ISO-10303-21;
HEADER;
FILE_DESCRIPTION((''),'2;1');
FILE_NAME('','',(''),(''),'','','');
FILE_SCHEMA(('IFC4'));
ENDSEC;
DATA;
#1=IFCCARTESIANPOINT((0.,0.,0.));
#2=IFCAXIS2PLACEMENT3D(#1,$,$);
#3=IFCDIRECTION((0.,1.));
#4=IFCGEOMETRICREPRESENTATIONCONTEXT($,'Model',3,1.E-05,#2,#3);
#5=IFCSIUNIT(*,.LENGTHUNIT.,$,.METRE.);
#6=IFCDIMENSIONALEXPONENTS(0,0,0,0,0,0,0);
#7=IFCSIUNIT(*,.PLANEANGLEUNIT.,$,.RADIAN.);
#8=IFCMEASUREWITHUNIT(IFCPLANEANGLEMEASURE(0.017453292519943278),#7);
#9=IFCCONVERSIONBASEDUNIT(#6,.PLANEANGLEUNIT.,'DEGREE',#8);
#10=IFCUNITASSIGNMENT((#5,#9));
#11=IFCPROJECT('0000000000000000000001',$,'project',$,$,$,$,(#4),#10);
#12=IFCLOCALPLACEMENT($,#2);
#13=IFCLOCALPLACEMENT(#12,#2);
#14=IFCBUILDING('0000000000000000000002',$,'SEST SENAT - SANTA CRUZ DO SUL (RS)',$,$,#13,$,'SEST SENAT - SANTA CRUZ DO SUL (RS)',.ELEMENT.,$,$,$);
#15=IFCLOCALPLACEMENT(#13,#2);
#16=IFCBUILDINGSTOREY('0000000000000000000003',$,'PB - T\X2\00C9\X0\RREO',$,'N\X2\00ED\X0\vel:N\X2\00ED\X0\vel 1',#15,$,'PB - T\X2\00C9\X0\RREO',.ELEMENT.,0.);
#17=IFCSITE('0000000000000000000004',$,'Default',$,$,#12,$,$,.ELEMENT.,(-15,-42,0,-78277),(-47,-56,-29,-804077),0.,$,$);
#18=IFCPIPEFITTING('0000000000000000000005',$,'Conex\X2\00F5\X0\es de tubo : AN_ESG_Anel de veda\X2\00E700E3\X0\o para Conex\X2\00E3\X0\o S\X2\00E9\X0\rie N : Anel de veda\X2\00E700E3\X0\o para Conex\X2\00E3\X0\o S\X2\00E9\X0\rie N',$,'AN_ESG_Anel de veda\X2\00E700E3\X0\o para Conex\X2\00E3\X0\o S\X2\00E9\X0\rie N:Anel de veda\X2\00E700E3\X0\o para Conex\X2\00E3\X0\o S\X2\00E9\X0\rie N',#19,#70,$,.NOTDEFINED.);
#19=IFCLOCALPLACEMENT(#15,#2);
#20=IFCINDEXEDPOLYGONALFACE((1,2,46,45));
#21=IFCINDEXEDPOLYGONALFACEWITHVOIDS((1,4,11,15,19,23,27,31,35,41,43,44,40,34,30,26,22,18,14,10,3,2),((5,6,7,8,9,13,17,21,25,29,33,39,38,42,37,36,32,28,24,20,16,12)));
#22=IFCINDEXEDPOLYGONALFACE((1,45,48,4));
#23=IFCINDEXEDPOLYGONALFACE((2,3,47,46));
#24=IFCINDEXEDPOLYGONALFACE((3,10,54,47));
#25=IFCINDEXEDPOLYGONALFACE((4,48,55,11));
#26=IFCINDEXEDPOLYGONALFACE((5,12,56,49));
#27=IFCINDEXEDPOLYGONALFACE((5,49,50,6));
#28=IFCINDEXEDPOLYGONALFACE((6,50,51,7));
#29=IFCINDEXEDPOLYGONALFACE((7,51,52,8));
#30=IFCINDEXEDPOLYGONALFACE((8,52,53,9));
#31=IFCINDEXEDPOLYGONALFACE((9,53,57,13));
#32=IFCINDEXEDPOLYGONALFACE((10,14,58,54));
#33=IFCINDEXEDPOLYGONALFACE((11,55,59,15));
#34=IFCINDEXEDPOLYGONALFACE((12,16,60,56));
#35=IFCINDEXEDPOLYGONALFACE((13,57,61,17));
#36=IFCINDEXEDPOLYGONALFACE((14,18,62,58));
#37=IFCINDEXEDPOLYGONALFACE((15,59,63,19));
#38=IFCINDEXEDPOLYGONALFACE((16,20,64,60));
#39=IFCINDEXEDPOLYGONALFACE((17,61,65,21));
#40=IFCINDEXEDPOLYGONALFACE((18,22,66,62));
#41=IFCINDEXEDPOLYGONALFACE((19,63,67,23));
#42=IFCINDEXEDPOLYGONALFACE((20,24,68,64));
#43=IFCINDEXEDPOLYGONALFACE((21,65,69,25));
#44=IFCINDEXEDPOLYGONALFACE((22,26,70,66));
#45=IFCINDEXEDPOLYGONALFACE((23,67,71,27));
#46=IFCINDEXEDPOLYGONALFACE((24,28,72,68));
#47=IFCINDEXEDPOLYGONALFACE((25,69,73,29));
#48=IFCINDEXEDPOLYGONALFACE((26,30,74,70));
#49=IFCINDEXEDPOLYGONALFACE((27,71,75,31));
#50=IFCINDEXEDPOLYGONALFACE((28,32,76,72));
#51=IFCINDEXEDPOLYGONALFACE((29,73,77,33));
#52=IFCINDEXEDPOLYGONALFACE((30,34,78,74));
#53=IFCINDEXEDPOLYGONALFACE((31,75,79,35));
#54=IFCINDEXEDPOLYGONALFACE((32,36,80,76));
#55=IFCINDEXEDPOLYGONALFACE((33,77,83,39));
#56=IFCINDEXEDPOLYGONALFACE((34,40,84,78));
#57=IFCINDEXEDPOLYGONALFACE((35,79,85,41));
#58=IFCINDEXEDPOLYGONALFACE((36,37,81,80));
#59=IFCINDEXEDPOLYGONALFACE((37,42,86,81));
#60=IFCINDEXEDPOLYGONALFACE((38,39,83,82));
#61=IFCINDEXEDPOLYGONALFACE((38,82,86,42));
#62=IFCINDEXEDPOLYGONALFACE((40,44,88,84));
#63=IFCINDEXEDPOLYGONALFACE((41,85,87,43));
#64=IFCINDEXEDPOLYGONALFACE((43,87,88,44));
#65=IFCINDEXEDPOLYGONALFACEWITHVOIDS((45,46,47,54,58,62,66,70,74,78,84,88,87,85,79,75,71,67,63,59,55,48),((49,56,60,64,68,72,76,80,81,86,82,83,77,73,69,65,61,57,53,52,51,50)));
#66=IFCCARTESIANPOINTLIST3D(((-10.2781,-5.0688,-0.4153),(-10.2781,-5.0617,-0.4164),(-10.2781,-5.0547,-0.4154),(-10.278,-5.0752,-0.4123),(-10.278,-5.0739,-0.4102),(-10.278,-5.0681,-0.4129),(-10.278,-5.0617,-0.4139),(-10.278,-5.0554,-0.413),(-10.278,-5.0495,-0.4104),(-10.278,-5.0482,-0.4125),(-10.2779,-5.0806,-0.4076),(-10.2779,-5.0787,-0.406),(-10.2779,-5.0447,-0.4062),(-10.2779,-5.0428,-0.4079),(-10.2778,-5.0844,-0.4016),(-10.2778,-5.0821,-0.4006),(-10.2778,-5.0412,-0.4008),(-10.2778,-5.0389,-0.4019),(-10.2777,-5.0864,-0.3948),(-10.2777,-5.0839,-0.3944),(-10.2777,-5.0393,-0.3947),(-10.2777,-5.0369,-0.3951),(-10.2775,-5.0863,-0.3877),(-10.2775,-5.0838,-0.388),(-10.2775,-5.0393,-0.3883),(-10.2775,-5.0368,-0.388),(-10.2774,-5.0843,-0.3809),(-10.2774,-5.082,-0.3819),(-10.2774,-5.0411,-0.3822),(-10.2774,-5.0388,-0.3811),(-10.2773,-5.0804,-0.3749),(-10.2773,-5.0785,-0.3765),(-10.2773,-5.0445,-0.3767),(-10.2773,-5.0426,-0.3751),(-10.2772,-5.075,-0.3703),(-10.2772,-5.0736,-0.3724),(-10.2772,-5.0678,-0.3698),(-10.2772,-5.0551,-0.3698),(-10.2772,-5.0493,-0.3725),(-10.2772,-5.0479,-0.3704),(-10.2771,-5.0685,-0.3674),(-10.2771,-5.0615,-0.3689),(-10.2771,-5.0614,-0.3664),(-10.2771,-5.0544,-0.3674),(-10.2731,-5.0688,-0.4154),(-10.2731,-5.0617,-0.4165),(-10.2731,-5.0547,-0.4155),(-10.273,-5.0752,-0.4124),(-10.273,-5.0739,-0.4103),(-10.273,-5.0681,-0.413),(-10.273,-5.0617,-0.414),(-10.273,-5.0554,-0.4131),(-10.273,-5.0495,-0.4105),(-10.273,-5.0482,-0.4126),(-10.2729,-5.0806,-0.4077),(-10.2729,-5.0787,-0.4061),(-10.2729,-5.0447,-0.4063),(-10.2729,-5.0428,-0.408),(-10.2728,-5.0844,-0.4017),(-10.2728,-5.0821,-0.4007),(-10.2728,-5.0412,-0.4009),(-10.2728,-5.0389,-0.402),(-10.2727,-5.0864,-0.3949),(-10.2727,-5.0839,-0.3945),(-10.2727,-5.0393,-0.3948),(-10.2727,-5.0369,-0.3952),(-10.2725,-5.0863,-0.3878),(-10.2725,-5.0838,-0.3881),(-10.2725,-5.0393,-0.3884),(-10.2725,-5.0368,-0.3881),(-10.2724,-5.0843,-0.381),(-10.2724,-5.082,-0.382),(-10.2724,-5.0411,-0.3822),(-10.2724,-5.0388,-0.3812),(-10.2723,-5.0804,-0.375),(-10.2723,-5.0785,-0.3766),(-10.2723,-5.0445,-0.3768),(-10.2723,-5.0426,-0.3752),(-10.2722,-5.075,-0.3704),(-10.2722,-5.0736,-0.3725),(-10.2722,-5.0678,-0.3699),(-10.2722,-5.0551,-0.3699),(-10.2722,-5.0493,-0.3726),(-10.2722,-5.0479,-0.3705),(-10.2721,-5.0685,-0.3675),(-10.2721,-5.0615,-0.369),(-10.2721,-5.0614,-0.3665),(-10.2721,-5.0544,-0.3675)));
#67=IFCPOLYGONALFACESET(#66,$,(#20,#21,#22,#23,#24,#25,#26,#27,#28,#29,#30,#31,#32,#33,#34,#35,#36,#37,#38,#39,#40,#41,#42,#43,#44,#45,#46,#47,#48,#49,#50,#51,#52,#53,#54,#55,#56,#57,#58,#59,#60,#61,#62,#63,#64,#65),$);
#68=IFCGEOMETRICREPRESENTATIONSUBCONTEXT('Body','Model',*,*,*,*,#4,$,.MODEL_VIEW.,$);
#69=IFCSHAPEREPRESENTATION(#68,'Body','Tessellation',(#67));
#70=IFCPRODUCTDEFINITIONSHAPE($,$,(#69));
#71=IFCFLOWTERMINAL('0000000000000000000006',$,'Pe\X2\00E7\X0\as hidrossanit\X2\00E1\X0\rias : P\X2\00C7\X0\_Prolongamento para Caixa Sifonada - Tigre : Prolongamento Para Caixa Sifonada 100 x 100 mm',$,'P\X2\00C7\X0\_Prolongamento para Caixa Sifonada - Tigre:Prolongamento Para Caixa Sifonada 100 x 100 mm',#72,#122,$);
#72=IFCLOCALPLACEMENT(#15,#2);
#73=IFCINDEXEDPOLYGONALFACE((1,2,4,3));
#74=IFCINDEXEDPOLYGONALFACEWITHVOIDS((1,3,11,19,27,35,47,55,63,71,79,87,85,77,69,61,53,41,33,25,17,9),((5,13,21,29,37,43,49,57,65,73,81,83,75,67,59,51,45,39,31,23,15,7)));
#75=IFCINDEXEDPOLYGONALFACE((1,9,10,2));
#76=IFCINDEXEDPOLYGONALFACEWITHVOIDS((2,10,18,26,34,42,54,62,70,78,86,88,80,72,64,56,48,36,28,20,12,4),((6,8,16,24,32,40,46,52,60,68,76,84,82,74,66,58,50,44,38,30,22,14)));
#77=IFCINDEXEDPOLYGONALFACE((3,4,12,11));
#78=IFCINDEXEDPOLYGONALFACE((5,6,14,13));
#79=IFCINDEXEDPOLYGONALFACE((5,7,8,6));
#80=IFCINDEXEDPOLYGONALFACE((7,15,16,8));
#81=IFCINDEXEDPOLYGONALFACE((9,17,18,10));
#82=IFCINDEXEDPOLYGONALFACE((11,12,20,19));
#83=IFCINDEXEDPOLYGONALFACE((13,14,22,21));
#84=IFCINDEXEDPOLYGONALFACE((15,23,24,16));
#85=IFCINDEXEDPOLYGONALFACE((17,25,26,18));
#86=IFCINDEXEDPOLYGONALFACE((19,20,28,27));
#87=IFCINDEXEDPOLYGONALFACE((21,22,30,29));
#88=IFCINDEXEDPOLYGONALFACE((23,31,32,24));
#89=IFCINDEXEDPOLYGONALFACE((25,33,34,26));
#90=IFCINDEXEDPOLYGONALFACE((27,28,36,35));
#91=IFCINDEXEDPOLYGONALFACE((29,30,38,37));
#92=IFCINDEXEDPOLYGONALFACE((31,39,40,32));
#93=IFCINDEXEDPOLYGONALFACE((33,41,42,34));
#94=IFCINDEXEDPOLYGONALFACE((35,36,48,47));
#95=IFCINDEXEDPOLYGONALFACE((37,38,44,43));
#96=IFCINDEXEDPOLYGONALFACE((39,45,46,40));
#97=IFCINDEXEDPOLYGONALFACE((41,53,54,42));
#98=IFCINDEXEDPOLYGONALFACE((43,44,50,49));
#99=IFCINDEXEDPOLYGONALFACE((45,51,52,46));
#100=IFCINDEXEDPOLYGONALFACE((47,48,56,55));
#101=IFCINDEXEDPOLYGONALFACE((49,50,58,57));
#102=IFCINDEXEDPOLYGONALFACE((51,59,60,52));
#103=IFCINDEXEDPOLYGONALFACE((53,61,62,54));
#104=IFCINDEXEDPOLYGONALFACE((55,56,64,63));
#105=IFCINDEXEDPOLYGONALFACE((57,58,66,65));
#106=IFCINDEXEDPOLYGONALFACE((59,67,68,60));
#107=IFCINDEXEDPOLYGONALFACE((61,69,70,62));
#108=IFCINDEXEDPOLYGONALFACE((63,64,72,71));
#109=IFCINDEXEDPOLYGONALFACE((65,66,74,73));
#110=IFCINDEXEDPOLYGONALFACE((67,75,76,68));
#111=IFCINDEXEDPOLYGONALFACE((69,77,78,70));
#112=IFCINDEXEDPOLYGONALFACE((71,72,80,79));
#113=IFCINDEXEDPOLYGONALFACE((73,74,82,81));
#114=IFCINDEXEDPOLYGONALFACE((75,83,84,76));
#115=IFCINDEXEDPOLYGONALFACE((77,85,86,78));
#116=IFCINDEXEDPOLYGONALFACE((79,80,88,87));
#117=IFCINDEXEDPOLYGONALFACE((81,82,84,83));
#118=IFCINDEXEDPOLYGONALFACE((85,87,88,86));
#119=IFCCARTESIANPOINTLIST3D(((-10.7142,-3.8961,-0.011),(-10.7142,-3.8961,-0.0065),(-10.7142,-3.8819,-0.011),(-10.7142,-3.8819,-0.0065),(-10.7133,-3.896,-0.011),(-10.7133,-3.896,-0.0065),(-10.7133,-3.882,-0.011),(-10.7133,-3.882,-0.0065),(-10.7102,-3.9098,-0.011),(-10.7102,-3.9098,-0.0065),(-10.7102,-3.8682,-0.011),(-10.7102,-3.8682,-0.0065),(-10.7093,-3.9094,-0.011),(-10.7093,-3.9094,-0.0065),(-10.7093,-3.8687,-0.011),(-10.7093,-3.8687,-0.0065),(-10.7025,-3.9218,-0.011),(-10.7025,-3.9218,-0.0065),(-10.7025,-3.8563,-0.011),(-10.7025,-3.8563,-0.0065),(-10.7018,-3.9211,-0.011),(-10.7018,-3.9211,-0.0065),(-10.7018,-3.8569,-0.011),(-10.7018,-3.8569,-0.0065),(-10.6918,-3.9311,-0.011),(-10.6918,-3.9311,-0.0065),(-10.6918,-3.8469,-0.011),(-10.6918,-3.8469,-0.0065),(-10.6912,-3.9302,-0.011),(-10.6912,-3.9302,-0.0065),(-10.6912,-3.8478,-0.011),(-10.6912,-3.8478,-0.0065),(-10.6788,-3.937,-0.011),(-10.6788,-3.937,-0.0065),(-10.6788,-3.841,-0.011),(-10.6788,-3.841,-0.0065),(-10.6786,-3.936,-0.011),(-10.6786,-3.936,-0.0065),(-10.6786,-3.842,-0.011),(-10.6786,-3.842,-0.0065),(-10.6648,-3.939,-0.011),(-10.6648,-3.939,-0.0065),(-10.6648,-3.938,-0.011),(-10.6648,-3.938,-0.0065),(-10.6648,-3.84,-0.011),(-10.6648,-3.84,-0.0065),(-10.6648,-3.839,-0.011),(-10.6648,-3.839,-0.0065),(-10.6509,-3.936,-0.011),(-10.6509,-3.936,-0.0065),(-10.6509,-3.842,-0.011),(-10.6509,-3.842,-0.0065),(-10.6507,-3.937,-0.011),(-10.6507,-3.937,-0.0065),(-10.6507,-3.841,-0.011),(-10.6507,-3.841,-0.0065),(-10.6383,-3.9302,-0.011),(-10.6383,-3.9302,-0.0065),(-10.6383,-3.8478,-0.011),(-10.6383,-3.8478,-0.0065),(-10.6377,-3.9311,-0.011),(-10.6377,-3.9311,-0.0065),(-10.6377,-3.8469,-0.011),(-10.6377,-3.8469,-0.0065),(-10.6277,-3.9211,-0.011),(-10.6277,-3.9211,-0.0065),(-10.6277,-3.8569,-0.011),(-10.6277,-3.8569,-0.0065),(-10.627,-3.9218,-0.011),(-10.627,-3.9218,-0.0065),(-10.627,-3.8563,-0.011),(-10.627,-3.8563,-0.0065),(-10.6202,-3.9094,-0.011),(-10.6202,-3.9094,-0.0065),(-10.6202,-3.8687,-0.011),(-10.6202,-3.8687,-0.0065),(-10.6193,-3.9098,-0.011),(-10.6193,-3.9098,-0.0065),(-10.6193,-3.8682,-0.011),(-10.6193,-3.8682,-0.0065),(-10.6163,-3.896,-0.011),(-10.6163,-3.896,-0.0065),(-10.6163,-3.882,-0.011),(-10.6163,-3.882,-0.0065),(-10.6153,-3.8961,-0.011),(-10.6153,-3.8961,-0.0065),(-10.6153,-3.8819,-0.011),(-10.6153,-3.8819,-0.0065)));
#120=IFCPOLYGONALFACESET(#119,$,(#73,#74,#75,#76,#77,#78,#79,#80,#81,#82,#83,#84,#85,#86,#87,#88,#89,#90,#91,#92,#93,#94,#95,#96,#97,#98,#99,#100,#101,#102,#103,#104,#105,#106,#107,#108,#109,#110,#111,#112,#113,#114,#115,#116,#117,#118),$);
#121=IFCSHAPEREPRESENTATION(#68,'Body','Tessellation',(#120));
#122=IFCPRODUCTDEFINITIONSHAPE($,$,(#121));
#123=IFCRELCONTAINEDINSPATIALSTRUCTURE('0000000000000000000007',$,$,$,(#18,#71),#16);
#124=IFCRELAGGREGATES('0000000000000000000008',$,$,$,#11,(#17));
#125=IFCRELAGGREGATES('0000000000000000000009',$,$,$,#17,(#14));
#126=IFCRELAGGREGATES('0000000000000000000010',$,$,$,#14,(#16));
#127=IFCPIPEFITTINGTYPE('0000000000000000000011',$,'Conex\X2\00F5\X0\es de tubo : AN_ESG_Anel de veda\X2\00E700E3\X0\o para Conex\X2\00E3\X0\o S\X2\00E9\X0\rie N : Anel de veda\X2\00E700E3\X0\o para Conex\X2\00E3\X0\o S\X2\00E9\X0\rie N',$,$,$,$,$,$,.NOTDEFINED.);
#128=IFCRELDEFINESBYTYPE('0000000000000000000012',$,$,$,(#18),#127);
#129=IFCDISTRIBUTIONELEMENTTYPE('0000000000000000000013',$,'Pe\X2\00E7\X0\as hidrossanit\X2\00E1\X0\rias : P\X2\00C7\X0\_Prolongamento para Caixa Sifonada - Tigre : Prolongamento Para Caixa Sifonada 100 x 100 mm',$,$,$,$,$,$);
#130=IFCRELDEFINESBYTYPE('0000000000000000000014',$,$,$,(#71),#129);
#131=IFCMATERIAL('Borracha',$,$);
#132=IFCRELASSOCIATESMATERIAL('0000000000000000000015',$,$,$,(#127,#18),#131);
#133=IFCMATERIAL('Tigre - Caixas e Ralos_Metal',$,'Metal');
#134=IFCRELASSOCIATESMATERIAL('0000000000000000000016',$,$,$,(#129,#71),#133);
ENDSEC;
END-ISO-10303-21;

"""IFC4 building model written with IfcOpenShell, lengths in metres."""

from ifc_helpers import new_model, entity, si_unit, converted_unit, direction, frame, origin, place, context, subcontext, project, spatial, arc, indexed_curve, outline, extrude, source, transform, mapped, material, type_object, type_shapes, element, save


model = new_model("IFC4")

# Units and contexts
model_context = context("Model", 3, precision=1e-05, world=origin(), true_north=direction((0.0, 1.0)))
body_context = subcontext(model_context, "Body", "Model", "MODEL_VIEW")
ifc_project = project(units=[si_unit("LENGTHUNIT", "METRE"), converted_unit("PLANEANGLEUNIT", "DEGREE", entity("IfcPlaneAngleMeasure", 0.017453292519943278), si_unit("PLANEANGLEUNIT", "RADIAN"), dimensions=[0, 0, 0, 0, 0, 0, 0])], contexts=[model_context])

# Site, building, storey
site_placement = place(None, origin())
site = spatial("IfcSite", under=ifc_project, at=site_placement, Name="Default", CompositionType="ELEMENT", RefLatitude=(-15, -42, 0, -78277), RefLongitude=(-47, -56, -29, -804077), RefElevation=0.0)
building_placement = place(site_placement, origin())
building = spatial("IfcBuilding", under=site, at=building_placement, Name="SEST SENAT - SANTA CRUZ DO SUL (RS)", LongName="SEST SENAT - SANTA CRUZ DO SUL (RS)", CompositionType="ELEMENT")
storey_placement = place(building_placement, origin())
storey = spatial("IfcBuildingStorey", under=building, at=storey_placement, Name="PB - TÉRREO", ObjectType="Nível:Nível 1", LongName="PB - TÉRREO", CompositionType="ELEMENT", Elevation=0.0)

# Pipe fitting
ifc_material_1 = material(Name="Borracha")
pipe_fitting_type_1 = type_object("IfcPipeFittingType", Name="Conexões de tubo : AN_ESG_Anel de vedação para Conexão Série N : Anel de vedação para Conexão Série N", PredefinedType="NOTDEFINED", material=ifc_material_1)
shared_shape_1 = source(origin(), body_context, "Body", "SweptSolid", [
    extrude(outline(indexed_curve([(-0.025, 0.0), (0.0, -0.025), (0.025, 0.0), (0.0, 0.025)], segments=[arc(1, 2, 3), arc(3, 4, 1)], self_intersect=False), holes=[indexed_curve([(-0.0225, 0.0), (0.0, 0.0225), (0.0225, 0.0), (0.0, -0.0225)], segments=[arc(1, 2, 3), arc(3, 4, 1)], self_intersect=False)]), frame((0.0, 0.0, -0.005)), (0.0, 0.0, 1.0), 0.005),
])
type_shapes(pipe_fitting_type_1, [shared_shape_1])
pipe_fitting_placement = place(storey_placement, frame((-10.2726, -5.0616, -0.3915), z_axis=(0.9998, 0.0, -0.019996), x_axis=(-0.019996, -0.005857, -0.999783)))
element("IfcPipeFitting", 1, at=pipe_fitting_placement, inside=storey, type_object=pipe_fitting_type_1, material=ifc_material_1, Name="Conexões de tubo : AN_ESG_Anel de vedação para Conexão Série N : Anel de vedação para Conexão Série N", ObjectType="AN_ESG_Anel de vedação para Conexão Série N:Anel de vedação para Conexão Série N", PredefinedType="NOTDEFINED", context=body_context, shape_type="MappedRepresentation", body=[
    mapped(shared_shape_1, transform((0.0, 0.0, 0.0), scale=1.0)),
])

# Flow terminal
ifc_material_2 = material(Name="Tigre - Caixas e Ralos_Metal", Category="Metal")
distribution_element_type = type_object("IfcDistributionElementType", Name="Peças hidrossanitárias : PÇ_Prolongamento para Caixa Sifonada - Tigre : Prolongamento Para Caixa Sifonada 100 x 100 mm", material=ifc_material_2)
shared_shape_2 = source(origin(), body_context, "Body", "SweptSolid", [
    extrude(outline(indexed_curve([(-0.05, 0.0), (0.0, -0.05), (0.05, 0.0), (0.0, 0.05)], segments=[arc(1, 2, 3), arc(3, 4, 1)], self_intersect=False), holes=[indexed_curve([(-0.049, 0.0), (0.0, 0.049), (0.049, 0.0), (0.0, -0.049)], segments=[arc(1, 2, 3), arc(3, 4, 1)], self_intersect=False)]), frame((0.0, 0.0, -0.0045)), (0.0, 0.0, 1.0), 0.0045),
])
type_shapes(distribution_element_type, [shared_shape_2])
flow_terminal_placement = place(storey_placement, frame((-10.6648, -3.889, -0.0065), z_axis=(0.0, 0.0, 1.0), x_axis=(0.0, 1.0, 0.0)))
element("IfcFlowTerminal", 2, at=flow_terminal_placement, inside=storey, type_object=distribution_element_type, material=ifc_material_2, Name="Peças hidrossanitárias : PÇ_Prolongamento para Caixa Sifonada - Tigre : Prolongamento Para Caixa Sifonada 100 x 100 mm", ObjectType="PÇ_Prolongamento para Caixa Sifonada - Tigre:Prolongamento Para Caixa Sifonada 100 x 100 mm", context=body_context, shape_type="MappedRepresentation", body=[
    mapped(shared_shape_2, transform((0.0, 0.0, 0.0), scale=1.0)),
])

save(model, "model.ifc")
